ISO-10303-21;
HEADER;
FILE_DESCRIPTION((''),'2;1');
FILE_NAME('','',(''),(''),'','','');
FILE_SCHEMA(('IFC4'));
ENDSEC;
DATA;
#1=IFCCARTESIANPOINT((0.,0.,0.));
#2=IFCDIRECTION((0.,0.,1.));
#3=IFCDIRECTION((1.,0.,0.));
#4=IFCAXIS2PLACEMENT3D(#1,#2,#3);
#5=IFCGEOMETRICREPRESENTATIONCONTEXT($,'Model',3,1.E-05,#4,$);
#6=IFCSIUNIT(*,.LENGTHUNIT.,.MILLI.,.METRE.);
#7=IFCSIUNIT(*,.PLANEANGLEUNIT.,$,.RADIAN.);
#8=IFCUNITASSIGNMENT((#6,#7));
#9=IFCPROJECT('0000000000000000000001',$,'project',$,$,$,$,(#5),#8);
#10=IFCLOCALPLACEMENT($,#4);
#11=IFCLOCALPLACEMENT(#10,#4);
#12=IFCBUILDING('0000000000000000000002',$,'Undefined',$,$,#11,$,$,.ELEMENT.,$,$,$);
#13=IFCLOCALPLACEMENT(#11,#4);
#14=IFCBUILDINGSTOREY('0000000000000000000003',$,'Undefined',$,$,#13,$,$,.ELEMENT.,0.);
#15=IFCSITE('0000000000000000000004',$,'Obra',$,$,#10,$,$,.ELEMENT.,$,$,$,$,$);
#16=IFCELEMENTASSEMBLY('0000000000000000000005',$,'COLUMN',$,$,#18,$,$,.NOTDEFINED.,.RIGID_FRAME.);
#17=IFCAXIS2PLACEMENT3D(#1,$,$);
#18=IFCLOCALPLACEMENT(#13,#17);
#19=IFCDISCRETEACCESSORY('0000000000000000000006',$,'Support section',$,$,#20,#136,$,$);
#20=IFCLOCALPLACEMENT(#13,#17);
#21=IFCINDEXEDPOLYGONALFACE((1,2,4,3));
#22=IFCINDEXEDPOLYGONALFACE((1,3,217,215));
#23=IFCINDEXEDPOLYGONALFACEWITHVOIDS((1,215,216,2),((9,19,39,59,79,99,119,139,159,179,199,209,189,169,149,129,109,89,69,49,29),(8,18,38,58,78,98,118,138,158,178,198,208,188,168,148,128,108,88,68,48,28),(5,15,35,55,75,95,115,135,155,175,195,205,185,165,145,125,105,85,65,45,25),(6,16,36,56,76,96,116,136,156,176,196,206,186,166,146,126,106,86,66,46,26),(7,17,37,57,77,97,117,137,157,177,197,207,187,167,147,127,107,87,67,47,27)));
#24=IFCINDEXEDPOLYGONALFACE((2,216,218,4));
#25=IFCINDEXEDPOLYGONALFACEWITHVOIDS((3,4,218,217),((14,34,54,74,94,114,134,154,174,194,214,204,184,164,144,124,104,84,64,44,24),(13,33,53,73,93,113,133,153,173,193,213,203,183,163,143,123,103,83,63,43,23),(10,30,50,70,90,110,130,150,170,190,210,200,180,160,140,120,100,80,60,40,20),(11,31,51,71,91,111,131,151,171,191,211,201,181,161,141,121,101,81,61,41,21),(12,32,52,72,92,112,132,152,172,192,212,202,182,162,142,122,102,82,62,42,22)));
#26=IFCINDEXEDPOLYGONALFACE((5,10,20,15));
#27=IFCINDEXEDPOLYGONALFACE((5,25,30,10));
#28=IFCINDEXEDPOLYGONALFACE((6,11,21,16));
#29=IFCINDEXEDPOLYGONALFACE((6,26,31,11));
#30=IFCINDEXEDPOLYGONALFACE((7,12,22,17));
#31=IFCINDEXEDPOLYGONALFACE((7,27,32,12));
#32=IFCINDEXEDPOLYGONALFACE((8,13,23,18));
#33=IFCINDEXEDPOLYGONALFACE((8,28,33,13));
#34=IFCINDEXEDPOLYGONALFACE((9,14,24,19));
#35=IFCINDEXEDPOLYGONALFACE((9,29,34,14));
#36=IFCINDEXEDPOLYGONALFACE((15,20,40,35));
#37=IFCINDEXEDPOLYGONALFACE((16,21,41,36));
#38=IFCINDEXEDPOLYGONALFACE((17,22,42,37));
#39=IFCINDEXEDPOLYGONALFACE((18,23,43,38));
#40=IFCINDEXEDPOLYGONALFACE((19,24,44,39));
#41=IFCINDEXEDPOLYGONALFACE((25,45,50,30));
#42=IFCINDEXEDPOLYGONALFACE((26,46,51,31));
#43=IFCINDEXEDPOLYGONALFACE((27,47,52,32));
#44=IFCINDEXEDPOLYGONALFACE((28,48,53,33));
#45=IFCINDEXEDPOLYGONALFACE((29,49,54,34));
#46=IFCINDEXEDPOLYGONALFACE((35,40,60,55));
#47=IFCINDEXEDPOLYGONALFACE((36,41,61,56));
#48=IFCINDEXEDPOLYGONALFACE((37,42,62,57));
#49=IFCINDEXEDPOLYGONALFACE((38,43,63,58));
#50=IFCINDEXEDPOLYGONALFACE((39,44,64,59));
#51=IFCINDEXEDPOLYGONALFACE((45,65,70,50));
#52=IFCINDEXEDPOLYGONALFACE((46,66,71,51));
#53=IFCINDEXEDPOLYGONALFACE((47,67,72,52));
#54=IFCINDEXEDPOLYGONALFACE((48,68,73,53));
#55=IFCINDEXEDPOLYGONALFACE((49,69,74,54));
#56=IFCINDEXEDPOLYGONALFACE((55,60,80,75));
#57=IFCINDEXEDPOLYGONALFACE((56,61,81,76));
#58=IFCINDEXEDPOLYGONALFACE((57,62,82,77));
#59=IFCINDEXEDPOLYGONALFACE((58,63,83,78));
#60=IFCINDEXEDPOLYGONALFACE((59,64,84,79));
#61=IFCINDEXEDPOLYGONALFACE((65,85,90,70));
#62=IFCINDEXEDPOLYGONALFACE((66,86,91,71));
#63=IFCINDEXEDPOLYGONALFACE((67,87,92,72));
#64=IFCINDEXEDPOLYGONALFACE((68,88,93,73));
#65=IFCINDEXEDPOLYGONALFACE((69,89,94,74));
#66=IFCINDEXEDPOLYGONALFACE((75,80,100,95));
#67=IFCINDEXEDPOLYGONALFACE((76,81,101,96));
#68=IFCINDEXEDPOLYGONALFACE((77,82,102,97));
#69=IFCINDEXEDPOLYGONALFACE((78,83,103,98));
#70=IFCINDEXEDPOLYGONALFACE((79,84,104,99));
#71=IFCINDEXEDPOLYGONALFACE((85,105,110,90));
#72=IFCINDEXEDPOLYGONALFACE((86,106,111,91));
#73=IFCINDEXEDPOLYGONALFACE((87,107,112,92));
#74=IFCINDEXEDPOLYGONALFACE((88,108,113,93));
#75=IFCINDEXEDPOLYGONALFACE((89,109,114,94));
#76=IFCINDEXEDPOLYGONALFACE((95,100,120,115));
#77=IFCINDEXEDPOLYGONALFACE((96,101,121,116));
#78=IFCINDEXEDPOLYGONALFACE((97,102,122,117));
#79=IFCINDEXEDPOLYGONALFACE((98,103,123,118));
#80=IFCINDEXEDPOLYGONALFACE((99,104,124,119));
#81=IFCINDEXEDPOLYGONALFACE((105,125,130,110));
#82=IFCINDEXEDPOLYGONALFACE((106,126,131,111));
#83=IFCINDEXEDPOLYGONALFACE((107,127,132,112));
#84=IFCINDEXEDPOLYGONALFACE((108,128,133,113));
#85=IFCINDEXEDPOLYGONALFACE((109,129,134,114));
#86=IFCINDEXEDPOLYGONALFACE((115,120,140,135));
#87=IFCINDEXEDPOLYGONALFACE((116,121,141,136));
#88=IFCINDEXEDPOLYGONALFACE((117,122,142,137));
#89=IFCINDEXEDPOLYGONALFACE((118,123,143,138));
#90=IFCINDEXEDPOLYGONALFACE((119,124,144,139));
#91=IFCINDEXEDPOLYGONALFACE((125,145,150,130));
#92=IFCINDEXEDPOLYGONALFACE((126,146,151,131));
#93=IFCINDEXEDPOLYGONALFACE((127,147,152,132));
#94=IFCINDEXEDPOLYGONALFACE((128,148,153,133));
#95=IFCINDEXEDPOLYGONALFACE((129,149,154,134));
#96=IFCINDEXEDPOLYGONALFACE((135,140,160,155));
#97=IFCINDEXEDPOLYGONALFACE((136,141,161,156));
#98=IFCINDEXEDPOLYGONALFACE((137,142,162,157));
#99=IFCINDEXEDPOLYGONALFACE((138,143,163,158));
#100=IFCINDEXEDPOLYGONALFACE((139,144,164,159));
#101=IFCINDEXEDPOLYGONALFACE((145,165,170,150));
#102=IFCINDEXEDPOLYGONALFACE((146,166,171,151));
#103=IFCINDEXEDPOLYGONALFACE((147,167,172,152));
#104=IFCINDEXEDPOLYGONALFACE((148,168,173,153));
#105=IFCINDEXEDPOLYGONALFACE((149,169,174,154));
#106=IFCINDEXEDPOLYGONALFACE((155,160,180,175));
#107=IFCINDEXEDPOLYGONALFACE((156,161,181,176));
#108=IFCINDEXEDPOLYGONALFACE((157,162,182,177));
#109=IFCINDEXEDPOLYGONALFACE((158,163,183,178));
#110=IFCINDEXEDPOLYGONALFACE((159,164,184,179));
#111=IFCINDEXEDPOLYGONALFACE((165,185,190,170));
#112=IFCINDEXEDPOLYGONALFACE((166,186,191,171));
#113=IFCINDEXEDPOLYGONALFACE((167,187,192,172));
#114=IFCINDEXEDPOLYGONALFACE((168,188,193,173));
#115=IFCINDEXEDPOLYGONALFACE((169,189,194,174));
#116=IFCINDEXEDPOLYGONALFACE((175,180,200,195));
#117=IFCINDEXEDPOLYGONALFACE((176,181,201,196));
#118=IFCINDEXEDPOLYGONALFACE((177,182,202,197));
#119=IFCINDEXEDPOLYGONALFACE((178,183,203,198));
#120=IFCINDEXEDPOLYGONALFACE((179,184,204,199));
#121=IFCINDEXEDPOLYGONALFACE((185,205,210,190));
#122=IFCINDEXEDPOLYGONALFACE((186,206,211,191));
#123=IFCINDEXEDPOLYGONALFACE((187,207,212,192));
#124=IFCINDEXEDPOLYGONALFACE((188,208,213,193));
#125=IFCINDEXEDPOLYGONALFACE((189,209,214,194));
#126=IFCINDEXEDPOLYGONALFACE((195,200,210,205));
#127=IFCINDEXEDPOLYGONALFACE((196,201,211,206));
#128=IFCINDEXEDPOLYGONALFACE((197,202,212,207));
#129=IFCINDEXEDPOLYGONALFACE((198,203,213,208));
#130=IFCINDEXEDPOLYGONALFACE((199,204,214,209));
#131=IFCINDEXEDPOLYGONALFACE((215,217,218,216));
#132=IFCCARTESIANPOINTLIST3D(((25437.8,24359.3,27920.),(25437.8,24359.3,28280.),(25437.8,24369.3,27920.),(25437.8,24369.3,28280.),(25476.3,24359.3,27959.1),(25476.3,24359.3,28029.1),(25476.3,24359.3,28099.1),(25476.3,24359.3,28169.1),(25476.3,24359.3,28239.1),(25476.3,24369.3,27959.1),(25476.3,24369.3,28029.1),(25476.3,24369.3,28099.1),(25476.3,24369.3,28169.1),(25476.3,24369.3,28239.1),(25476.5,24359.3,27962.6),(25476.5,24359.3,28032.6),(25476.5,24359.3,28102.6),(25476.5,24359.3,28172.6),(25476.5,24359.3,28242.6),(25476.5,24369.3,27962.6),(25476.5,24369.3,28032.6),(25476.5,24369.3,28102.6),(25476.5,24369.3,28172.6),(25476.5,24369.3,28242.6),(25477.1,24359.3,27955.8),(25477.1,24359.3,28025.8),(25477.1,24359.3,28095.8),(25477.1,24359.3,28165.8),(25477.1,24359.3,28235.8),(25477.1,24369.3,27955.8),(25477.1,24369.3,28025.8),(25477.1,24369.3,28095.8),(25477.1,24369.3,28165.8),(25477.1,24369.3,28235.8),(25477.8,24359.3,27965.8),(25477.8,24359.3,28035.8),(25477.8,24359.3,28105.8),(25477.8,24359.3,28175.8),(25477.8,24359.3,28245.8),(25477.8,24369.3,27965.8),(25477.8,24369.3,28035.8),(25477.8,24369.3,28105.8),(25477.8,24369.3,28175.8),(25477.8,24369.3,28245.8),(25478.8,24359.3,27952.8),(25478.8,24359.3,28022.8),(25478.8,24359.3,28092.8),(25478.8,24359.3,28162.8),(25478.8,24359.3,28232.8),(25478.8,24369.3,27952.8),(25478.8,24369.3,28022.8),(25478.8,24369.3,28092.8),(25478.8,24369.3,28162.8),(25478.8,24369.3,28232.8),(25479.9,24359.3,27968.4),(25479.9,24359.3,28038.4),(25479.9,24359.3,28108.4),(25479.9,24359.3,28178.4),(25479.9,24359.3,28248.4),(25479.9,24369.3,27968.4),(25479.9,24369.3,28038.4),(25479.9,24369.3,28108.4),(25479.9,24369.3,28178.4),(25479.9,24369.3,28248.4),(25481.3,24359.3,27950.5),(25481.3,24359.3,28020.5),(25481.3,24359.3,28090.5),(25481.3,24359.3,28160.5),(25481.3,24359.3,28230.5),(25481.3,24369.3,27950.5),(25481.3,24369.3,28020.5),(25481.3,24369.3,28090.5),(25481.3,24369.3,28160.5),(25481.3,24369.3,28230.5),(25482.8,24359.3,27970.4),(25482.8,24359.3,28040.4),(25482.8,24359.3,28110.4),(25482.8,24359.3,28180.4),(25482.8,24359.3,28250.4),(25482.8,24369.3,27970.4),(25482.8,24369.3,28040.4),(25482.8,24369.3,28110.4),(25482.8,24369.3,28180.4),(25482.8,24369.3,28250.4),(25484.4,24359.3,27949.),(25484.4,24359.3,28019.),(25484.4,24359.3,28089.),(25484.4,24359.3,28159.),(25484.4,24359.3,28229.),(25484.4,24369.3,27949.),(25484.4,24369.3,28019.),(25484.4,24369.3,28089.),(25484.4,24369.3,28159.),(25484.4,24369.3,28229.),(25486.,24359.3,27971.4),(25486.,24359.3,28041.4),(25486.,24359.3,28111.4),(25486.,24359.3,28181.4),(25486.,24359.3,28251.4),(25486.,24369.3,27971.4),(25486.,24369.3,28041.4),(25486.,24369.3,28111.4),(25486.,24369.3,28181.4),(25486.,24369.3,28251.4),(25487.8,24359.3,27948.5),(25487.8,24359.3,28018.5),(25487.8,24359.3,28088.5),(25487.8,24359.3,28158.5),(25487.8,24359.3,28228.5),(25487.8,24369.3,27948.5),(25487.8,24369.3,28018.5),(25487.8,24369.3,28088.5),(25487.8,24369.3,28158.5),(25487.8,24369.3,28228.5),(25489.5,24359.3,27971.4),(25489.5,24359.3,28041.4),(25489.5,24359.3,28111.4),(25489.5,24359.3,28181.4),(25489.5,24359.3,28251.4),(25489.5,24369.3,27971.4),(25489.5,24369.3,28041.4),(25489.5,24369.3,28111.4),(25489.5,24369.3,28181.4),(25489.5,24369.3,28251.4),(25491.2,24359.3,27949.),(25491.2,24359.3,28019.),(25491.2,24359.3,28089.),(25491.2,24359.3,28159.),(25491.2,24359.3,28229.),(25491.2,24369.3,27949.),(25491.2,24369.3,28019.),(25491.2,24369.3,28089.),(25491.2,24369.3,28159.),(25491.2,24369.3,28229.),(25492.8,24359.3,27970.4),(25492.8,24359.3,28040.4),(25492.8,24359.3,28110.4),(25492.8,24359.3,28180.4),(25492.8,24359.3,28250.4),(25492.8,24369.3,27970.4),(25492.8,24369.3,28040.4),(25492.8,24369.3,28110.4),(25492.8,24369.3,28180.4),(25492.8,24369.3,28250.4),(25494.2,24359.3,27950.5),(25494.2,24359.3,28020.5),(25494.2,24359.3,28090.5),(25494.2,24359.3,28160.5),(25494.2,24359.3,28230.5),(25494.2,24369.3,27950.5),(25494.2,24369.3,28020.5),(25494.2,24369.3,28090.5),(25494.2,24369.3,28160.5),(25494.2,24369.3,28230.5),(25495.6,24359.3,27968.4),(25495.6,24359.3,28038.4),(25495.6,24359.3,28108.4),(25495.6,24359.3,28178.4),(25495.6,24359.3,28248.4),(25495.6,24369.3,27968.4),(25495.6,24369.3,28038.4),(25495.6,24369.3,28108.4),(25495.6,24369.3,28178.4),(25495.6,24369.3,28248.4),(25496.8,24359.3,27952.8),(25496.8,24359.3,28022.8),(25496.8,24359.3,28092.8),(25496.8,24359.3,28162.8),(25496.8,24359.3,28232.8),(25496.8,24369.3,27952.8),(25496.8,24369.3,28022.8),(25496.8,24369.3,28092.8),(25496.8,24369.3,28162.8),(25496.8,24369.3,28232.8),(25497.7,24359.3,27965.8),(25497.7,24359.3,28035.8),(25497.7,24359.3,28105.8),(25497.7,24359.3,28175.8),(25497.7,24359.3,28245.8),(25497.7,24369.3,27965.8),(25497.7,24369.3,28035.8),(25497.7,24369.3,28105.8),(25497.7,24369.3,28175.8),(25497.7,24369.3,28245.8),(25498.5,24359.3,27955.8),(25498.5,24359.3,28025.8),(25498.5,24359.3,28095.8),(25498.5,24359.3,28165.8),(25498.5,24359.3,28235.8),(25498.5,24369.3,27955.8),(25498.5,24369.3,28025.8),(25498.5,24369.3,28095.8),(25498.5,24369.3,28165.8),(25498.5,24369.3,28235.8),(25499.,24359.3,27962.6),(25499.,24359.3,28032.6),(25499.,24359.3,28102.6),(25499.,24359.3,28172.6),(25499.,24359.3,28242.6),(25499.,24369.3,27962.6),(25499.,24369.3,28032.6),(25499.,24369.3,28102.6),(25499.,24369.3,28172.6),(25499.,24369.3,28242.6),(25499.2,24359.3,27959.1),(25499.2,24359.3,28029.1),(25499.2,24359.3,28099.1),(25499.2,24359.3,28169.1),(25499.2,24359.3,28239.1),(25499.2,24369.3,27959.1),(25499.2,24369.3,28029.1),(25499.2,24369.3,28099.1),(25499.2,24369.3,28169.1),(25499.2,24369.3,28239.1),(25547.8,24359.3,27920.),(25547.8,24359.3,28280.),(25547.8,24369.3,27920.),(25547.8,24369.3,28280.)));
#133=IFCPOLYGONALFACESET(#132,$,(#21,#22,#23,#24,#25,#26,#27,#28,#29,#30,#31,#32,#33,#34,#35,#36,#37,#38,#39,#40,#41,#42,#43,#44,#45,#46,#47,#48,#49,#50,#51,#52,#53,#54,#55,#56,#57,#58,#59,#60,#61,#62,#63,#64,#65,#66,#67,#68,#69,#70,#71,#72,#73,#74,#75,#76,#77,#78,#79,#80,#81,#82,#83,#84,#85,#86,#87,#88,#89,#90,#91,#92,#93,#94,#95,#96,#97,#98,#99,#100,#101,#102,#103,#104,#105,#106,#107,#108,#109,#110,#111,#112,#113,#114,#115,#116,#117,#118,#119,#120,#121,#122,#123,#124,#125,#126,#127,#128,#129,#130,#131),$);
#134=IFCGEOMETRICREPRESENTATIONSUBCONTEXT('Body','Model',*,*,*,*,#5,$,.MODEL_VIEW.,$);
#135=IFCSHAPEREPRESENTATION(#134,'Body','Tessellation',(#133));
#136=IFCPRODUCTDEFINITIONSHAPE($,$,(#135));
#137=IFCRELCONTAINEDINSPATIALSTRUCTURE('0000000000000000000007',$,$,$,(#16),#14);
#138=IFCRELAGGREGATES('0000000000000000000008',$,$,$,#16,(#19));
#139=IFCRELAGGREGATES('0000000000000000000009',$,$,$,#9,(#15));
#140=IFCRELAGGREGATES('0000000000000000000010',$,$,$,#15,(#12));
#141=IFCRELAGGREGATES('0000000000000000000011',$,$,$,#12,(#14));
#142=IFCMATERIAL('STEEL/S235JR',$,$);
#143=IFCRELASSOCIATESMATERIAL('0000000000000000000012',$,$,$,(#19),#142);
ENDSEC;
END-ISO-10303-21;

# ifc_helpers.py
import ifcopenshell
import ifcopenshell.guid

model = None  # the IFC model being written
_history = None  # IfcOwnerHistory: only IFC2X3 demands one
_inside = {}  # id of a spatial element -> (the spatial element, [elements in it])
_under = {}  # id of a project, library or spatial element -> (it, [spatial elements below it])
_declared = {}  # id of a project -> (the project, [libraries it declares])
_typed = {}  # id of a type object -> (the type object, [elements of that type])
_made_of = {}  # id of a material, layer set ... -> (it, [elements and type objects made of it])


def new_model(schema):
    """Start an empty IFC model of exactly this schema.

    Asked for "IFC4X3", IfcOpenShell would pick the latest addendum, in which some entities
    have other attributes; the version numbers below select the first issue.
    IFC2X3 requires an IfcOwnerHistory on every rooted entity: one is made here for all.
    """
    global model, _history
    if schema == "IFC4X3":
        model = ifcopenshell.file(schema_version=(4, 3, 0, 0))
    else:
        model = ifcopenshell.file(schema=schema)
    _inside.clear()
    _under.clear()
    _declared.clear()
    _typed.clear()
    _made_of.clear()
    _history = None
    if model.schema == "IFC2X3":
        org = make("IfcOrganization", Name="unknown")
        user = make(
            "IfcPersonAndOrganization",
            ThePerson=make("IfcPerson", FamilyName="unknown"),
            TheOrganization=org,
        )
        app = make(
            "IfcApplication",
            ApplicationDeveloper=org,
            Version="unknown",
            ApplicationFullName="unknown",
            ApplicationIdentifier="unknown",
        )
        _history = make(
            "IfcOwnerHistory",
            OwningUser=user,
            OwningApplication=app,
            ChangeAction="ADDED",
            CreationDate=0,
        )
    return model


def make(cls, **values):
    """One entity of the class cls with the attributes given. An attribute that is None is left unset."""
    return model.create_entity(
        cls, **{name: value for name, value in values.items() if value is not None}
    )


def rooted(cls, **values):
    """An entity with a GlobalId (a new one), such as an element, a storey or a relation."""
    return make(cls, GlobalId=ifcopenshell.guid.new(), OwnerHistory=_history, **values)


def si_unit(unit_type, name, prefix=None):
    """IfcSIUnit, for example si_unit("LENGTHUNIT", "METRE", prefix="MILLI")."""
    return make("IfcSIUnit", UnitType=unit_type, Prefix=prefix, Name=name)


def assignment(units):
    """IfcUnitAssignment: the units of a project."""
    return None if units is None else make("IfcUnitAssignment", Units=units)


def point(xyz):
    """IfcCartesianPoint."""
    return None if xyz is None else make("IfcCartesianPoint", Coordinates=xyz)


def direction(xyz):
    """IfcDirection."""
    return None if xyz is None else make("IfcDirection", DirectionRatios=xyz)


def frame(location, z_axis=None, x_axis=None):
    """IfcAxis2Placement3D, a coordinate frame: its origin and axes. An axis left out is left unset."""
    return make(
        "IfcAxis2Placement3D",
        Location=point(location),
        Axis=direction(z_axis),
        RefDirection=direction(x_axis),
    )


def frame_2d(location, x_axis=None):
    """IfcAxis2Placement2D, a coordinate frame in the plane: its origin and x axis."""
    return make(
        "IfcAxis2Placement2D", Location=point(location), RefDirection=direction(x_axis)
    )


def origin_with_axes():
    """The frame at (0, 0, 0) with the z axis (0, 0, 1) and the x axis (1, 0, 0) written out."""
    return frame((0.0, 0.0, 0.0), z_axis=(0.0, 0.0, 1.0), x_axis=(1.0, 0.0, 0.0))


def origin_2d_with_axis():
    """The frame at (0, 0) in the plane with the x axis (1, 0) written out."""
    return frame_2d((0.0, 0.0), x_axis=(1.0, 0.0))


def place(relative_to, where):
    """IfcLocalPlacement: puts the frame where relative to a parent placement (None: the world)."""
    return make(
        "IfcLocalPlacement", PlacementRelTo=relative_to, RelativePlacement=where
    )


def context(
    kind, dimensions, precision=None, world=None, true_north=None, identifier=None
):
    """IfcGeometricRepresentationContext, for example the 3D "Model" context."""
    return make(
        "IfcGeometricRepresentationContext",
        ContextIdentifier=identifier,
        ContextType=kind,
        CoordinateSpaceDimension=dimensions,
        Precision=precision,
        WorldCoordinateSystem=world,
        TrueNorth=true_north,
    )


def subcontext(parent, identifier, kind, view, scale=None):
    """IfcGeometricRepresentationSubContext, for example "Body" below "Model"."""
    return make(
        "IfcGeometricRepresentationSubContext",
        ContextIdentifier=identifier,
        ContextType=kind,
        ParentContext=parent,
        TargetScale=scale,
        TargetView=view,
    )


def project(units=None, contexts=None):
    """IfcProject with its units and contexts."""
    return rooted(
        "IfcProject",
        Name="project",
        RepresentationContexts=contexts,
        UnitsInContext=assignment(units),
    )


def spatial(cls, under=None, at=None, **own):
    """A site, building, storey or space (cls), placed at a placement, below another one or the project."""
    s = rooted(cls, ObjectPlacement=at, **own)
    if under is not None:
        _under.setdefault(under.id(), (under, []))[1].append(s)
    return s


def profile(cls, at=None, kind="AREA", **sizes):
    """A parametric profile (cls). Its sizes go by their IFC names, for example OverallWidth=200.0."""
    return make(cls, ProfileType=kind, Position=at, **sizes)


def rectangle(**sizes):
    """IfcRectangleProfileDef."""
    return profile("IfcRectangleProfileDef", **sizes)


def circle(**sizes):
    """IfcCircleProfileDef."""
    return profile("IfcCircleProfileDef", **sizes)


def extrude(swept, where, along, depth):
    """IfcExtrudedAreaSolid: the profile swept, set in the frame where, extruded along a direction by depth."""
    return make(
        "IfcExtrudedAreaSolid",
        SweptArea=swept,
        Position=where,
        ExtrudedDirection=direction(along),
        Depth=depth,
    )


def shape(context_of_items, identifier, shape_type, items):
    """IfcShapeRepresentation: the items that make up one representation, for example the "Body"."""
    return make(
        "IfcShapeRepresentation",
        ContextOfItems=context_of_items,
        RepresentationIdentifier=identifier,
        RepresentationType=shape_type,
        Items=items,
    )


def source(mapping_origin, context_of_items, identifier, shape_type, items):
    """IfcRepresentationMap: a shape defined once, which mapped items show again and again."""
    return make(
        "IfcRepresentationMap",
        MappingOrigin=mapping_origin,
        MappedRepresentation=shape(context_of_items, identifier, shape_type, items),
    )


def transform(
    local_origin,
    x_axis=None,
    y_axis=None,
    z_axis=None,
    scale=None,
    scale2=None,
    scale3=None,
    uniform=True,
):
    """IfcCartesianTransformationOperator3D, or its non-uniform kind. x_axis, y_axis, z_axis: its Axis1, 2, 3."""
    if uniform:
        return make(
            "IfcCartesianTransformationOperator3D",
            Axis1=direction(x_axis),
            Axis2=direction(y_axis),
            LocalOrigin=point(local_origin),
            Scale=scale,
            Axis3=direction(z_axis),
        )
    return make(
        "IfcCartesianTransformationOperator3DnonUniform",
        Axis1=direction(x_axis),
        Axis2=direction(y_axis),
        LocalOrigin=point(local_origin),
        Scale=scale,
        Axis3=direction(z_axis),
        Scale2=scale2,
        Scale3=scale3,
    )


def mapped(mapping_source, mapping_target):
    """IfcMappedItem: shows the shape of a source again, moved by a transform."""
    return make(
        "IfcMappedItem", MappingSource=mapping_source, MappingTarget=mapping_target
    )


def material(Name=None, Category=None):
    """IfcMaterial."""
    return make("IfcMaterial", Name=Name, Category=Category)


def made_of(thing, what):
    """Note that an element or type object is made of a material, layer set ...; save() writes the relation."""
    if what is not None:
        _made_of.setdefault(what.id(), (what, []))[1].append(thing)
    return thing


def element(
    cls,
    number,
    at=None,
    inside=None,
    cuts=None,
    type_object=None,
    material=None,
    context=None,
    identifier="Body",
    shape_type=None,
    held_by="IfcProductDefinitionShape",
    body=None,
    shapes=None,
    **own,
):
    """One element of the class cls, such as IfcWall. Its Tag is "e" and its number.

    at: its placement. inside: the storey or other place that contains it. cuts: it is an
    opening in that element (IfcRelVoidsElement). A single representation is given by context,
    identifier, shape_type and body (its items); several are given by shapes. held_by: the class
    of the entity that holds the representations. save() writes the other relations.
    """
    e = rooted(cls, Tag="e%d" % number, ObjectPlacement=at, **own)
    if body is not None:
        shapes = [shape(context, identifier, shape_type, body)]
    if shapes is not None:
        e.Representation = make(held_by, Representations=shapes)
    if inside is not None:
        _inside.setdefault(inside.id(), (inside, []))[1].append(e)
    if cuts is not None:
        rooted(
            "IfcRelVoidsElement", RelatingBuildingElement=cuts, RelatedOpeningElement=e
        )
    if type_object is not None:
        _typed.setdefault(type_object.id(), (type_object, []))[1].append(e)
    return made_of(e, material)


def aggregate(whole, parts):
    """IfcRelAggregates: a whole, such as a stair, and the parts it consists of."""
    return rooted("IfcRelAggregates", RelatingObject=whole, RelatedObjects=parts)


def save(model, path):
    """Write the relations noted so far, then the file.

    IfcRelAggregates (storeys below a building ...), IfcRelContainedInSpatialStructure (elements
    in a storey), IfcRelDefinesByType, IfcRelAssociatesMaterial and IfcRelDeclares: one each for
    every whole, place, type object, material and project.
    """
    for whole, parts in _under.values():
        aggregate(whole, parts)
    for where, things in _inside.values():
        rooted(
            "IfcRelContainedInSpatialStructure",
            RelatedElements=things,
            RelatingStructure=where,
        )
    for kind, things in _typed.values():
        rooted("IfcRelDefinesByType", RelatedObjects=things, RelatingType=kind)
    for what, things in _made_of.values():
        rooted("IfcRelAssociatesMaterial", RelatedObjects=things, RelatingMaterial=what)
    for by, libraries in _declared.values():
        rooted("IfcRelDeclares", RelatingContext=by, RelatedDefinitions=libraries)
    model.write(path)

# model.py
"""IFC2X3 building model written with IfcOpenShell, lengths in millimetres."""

from ifc_helpers import new_model, si_unit, frame, origin_with_axes, origin_2d_with_axis, place, context, subcontext, project, spatial, rectangle, circle, extrude, source, transform, mapped, material, element, aggregate, save


model = new_model("IFC2X3")

# Units and contexts
model_context = context("Model", 3, precision=1e-05, world=origin_with_axes())
body_context = subcontext(model_context, "Body", "Model", "MODEL_VIEW")
ifc_project = project(units=[si_unit("LENGTHUNIT", "METRE", prefix="MILLI"), si_unit("PLANEANGLEUNIT", "RADIAN")], contexts=[model_context])

# Site, building, storey
site_placement = place(None, origin_with_axes())
site = spatial("IfcSite", under=ifc_project, at=site_placement, Name="Obra", CompositionType="ELEMENT")
building_placement = place(site_placement, origin_with_axes())
building = spatial("IfcBuilding", under=site, at=building_placement, Name="Undefined", CompositionType="ELEMENT")
storey_placement = place(building_placement, origin_with_axes())
storey = spatial("IfcBuildingStorey", under=building, at=storey_placement, Name="Undefined", CompositionType="ELEMENT", Elevation=0.0)

# Element assembly
ifc_material_1 = material(Name="STEEL/S235JR")
assembly_1_placement = place(storey_placement, origin_with_axes())
assembly_1 = element("IfcElementAssembly", 1, at=assembly_1_placement, inside=storey, Name="COLUMN", AssemblyPlace="NOTDEFINED", PredefinedType="RIGID_FRAME")

# Discrete accessory, opening
shared_shape_1 = source(origin_with_axes(), body_context, "Body", "SweptSolid", [
    extrude(circle(Radius=11.5, at=origin_2d_with_axis()), frame((0.0, -14.4, 0.0), z_axis=(0.0, 1.0, 0.0), x_axis=(1.0, 0.0, 0.0)), (0.0, 0.0, 1.0), 10.2),
])
discrete_accessory_1_placement = place(assembly_1_placement, frame((25492.8, 24364.3, 27920.0), z_axis=(0.0, 0.0, 1.0), x_axis=(1.0, 0.0, 0.0)))
discrete_accessory_1 = element("IfcDiscreteAccessory", 2, at=discrete_accessory_1_placement, material=ifc_material_1, Name="Support section", context=body_context, shape_type="SweptSolid", body=[
    extrude(rectangle(XDim=10.0, YDim=110.0, at=origin_2d_with_axis()), frame((0.0, 0.0, 360.0), z_axis=(0.0, 0.0, -1.0), x_axis=(0.0, 1.0, 0.0)), (0.0, 0.0, 1.0), 360.0),
])
opening_1_placement = place(assembly_1_placement, frame((25537.8, 24355.0, 28300.0), z_axis=(-1.0, 0.0, 0.0), x_axis=(0.0, 0.0, -1.0)))
element("IfcOpeningElement", 3, at=opening_1_placement, cuts=discrete_accessory_1, ObjectType="Opening", context=body_context, shape_type="MappedRepresentation", body=[
    mapped(shared_shape_1, transform((60.0, 0.0, 50.0))),
    mapped(shared_shape_1, transform((130.0, 0.0, 50.0))),
    mapped(shared_shape_1, transform((200.0, 0.0, 50.0))),
    mapped(shared_shape_1, transform((270.0, 0.0, 50.0))),
    mapped(shared_shape_1, transform((340.0, 0.0, 50.0))),
])
aggregate(assembly_1, [discrete_accessory_1])

save(model, "model.ifc")
